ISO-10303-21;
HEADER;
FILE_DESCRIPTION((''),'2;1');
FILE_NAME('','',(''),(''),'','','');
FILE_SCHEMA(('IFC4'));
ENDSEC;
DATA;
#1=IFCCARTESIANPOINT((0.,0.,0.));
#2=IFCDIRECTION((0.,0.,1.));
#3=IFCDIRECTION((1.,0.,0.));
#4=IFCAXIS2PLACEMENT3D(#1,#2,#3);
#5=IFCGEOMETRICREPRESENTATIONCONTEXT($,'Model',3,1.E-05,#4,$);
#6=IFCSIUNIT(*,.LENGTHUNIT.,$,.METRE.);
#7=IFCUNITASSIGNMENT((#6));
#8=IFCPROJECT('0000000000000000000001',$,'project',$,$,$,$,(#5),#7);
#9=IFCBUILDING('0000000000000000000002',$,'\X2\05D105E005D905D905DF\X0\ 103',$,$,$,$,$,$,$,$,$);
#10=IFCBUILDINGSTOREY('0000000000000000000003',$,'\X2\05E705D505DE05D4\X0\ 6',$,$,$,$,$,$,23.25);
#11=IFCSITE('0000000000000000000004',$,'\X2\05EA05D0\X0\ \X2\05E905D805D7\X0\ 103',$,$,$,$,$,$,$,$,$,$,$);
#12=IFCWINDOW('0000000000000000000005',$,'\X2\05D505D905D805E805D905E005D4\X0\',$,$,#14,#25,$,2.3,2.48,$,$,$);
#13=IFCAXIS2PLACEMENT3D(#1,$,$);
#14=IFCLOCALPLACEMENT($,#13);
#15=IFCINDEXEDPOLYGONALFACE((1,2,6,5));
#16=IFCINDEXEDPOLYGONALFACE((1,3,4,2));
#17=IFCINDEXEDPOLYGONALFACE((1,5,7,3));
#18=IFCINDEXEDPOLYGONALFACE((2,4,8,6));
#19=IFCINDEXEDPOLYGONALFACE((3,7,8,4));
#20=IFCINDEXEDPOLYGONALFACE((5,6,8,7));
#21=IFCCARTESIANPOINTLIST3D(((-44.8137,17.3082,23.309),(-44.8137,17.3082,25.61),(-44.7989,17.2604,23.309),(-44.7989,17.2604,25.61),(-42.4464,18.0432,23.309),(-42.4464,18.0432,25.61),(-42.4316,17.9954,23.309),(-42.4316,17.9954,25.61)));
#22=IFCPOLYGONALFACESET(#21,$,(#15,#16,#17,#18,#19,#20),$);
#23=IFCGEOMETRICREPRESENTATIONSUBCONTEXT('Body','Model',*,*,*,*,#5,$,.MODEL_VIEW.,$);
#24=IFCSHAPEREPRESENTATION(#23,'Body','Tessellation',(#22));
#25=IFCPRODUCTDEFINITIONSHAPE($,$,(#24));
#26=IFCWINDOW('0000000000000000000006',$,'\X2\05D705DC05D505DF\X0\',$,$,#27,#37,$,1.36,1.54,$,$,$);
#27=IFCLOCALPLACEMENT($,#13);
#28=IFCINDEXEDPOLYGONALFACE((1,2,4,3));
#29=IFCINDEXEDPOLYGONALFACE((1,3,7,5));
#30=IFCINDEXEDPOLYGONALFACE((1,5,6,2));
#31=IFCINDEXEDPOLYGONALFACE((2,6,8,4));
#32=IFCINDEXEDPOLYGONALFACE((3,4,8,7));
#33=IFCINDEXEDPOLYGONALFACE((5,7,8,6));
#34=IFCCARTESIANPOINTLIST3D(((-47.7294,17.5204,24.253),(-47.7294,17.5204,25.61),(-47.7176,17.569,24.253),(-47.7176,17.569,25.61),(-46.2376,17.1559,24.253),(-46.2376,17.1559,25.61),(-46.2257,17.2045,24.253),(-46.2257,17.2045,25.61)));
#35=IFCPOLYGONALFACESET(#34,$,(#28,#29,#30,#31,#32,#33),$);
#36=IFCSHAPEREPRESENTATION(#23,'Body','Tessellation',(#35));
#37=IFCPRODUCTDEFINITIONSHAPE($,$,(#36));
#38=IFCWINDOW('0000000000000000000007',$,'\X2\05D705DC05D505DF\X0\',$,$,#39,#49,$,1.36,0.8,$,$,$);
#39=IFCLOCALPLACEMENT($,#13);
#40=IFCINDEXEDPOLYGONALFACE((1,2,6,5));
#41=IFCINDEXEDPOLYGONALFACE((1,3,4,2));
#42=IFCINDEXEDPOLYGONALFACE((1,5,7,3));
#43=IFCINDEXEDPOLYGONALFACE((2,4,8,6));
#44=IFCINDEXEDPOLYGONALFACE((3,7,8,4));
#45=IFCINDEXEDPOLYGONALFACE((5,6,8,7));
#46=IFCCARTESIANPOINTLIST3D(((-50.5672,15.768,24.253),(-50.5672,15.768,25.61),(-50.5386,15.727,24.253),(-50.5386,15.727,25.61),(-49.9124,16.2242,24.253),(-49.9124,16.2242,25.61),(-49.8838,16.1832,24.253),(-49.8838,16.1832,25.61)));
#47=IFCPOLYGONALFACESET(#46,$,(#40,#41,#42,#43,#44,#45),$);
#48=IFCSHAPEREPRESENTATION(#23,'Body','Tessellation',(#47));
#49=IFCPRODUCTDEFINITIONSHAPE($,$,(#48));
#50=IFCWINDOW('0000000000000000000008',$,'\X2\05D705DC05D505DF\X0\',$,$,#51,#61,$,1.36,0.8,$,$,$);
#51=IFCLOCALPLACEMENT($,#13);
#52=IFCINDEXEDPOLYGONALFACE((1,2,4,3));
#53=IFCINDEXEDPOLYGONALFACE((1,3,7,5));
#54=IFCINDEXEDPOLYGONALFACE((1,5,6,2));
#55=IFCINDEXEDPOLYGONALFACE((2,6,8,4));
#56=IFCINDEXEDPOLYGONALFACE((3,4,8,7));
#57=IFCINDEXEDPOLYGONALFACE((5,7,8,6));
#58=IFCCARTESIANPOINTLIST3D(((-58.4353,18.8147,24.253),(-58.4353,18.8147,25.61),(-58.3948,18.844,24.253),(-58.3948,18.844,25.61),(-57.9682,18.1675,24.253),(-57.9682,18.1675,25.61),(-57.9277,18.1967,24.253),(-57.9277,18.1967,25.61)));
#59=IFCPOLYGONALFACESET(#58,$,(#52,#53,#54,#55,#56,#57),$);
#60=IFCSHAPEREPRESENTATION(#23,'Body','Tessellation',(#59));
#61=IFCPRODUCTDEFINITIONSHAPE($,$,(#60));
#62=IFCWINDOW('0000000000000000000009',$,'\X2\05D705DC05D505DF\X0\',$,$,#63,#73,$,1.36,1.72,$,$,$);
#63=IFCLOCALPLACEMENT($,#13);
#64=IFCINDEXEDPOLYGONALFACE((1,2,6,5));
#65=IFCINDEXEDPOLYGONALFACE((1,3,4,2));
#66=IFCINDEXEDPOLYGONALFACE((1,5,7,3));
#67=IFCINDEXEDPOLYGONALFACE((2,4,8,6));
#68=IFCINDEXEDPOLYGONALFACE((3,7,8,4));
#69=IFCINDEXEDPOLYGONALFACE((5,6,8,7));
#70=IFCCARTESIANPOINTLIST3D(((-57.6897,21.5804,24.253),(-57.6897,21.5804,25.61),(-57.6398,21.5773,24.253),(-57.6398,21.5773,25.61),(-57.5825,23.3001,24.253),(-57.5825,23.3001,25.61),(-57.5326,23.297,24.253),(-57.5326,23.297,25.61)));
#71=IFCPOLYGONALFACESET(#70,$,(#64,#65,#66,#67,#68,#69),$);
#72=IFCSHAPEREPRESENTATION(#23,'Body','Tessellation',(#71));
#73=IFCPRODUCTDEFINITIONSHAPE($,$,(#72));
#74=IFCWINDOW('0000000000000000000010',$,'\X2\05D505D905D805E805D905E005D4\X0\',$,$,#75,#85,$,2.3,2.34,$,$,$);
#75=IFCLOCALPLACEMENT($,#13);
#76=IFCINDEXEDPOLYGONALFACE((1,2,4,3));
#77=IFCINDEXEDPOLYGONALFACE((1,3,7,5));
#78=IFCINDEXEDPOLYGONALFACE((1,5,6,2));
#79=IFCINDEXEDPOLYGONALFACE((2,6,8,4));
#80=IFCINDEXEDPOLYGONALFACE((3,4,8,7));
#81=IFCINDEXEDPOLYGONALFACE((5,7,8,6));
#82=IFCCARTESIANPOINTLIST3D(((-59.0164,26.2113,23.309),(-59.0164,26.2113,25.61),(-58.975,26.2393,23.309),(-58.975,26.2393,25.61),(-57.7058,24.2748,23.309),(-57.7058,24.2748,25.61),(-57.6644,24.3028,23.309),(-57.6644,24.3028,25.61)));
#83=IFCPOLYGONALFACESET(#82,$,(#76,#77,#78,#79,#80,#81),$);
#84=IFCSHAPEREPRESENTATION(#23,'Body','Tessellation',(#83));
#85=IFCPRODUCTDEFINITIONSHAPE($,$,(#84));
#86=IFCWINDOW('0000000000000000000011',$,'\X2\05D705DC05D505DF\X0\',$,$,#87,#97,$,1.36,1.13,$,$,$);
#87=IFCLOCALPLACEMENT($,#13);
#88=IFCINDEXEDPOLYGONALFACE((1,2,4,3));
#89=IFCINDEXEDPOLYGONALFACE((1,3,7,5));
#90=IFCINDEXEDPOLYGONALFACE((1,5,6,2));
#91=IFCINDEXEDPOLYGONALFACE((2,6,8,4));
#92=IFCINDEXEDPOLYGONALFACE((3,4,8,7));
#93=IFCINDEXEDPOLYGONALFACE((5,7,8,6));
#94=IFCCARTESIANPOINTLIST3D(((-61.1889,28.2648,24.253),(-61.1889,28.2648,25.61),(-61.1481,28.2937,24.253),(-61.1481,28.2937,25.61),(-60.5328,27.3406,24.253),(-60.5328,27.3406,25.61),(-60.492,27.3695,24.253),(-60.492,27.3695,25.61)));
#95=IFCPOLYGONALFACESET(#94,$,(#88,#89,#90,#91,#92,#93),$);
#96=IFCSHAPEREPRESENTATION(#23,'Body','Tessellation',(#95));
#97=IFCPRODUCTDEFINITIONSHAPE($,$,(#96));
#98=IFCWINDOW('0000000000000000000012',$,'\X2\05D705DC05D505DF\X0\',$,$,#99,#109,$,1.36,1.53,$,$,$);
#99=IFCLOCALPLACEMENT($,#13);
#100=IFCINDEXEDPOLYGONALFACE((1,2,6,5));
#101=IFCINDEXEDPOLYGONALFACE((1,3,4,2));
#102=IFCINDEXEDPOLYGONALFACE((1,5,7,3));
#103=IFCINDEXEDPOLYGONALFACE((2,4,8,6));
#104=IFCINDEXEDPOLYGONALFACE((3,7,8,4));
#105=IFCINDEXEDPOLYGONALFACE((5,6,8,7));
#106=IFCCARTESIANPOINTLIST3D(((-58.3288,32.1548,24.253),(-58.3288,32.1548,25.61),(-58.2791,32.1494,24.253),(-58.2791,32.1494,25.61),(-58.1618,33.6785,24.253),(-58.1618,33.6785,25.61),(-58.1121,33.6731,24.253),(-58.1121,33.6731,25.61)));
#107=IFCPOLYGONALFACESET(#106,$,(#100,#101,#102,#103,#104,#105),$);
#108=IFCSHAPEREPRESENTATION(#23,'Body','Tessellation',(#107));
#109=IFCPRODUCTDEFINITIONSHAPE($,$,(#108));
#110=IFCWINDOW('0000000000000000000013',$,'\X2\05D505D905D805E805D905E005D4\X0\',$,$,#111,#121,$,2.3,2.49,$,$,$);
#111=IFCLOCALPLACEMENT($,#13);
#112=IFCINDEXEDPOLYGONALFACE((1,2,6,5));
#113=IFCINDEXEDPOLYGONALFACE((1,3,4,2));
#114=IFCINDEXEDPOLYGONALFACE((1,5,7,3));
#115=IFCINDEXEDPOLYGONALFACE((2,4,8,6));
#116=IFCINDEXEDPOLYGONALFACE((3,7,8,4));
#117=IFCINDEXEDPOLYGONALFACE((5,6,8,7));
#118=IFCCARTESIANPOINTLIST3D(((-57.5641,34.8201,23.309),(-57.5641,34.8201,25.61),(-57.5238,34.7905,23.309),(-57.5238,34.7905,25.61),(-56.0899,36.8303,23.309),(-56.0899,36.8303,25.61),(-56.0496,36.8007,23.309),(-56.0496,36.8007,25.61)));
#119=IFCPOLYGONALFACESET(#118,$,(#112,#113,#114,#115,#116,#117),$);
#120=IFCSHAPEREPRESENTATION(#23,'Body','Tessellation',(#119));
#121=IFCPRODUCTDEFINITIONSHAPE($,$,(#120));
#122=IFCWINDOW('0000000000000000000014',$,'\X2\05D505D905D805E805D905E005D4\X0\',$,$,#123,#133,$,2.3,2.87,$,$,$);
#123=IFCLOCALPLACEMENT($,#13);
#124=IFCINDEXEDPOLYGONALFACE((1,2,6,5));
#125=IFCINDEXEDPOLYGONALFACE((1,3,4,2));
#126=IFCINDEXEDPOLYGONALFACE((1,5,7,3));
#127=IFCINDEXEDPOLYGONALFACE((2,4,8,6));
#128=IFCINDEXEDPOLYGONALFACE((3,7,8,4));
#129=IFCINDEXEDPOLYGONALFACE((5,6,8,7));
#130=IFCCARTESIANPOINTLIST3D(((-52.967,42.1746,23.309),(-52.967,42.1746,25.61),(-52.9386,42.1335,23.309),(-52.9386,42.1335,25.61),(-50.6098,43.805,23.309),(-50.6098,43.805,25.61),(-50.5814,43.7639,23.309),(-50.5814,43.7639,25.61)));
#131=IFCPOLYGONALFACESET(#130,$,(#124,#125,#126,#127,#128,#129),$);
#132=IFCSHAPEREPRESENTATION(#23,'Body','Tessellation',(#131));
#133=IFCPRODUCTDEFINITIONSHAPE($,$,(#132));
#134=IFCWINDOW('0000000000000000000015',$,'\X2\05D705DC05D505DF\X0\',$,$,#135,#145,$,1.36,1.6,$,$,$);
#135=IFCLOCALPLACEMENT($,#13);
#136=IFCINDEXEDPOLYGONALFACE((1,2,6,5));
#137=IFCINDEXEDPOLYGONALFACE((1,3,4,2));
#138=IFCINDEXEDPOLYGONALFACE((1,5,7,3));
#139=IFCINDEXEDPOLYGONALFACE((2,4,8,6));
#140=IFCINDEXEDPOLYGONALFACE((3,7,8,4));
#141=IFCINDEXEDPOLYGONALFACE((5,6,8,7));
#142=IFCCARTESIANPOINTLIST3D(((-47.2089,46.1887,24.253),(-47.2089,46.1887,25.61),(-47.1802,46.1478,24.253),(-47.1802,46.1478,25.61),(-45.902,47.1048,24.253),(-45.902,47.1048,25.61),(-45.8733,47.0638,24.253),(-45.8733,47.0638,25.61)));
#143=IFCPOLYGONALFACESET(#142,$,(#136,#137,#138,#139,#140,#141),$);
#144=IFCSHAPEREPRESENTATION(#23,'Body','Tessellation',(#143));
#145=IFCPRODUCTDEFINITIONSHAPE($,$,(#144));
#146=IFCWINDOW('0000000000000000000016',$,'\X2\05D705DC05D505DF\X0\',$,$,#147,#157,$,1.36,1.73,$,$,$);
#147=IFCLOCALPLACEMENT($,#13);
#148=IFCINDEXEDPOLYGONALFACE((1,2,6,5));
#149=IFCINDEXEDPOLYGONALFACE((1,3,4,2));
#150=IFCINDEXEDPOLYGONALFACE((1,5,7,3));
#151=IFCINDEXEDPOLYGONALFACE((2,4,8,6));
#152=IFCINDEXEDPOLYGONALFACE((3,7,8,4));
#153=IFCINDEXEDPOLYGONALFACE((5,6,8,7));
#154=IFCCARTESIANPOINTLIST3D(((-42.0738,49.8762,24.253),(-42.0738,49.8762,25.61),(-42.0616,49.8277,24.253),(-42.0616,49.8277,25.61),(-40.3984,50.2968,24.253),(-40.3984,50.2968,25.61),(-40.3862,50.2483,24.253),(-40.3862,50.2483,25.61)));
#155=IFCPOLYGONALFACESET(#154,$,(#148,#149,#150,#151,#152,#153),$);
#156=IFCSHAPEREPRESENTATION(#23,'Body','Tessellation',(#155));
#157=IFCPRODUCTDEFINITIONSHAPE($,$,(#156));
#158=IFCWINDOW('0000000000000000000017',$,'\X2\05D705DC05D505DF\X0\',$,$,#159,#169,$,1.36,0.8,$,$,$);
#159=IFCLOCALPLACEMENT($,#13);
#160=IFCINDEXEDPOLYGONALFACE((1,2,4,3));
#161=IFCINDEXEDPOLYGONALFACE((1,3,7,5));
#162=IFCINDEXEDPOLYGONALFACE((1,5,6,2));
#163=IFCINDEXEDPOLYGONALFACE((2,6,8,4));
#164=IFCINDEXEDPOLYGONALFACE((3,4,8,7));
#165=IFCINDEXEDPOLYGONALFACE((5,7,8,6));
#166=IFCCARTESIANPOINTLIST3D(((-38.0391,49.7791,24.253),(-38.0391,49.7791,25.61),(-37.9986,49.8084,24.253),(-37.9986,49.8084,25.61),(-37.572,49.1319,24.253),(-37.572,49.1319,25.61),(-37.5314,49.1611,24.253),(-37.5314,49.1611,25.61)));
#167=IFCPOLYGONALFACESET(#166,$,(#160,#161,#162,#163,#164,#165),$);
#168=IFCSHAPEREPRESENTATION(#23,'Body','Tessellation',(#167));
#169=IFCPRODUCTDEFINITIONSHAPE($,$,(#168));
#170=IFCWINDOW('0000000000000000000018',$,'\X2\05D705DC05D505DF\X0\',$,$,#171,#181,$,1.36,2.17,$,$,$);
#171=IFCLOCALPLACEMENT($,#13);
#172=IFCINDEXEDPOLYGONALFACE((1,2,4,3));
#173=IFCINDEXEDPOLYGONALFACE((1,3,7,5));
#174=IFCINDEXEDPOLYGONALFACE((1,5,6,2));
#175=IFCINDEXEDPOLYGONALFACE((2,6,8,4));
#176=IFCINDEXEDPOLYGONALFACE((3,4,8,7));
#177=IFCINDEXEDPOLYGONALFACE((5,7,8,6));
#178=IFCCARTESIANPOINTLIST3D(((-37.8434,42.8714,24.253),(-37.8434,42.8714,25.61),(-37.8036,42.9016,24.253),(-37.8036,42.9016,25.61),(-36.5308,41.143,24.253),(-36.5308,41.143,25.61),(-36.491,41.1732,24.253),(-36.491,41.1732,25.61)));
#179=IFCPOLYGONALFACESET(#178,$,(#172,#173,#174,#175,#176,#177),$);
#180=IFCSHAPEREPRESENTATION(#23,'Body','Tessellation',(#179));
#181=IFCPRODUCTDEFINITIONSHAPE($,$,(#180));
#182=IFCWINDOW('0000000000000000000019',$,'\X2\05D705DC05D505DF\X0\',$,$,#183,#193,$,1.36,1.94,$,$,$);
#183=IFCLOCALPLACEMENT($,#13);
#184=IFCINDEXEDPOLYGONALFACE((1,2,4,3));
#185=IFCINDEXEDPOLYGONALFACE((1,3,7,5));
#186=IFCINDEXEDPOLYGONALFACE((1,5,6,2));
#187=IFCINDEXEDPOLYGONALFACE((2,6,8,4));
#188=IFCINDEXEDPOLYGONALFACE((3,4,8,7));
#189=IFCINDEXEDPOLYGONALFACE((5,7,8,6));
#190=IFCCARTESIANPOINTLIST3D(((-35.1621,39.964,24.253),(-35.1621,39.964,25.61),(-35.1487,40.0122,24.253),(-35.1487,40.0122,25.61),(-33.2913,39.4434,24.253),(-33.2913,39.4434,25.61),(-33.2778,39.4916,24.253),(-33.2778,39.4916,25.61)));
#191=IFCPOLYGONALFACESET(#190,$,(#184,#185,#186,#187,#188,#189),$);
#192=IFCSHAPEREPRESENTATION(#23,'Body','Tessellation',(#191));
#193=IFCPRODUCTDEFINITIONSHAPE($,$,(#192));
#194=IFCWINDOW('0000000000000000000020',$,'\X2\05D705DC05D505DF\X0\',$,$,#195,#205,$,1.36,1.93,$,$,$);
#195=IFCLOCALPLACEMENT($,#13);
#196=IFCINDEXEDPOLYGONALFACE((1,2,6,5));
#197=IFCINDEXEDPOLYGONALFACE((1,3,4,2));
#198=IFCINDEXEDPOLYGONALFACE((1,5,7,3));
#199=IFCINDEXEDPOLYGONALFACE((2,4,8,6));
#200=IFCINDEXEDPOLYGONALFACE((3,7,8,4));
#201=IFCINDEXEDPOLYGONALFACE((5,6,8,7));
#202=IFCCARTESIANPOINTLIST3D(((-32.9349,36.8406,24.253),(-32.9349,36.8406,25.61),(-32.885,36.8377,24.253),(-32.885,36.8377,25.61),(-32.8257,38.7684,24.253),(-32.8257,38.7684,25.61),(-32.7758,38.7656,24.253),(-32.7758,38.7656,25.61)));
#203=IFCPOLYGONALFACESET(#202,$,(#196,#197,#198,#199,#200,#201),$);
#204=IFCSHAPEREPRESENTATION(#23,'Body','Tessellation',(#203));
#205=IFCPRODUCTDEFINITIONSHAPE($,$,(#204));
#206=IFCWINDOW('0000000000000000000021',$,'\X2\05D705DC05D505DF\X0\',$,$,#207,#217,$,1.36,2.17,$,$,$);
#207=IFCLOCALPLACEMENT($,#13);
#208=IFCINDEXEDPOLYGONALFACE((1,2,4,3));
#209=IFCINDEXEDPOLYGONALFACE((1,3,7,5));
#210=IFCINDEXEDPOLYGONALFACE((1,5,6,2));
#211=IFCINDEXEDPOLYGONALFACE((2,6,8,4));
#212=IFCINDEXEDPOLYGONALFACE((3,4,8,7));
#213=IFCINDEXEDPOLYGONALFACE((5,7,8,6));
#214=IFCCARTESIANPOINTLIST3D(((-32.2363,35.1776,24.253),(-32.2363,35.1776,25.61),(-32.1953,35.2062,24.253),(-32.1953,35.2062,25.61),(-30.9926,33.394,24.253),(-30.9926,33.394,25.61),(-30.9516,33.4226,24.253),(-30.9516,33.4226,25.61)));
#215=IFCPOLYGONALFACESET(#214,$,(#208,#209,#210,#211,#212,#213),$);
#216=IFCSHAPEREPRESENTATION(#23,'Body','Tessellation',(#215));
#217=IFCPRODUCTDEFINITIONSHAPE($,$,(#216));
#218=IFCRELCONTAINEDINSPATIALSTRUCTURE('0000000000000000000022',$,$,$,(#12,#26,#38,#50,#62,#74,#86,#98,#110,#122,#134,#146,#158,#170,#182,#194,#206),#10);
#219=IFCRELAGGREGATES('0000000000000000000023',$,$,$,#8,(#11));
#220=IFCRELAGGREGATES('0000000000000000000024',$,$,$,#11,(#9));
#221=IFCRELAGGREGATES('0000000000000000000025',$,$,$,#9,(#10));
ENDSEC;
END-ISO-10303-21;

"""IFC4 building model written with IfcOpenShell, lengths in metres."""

from ifc_helpers import new_model, si_unit, frame, origin_with_axes, context, subcontext, project, spatial, polyline, outline, extrude, element, save


model = new_model("IFC4")

# Units and contexts
model_context = context("Model", 3, precision=1e-05, world=origin_with_axes())
body_context = subcontext(model_context, "Body", "Model", "MODEL_VIEW")
ifc_project = project(units=[si_unit("LENGTHUNIT", "METRE")], contexts=[model_context])

# Site, building, storey
site = spatial("IfcSite", under=ifc_project, Name="תא שטח 103")
building = spatial("IfcBuilding", under=site, Name="בניין 103")
storey = spatial("IfcBuildingStorey", under=building, Name="קומה 6", Elevation=23.25)

# Windows
element("IfcWindow", 1, inside=storey, Name="ויטרינה", OverallHeight=2.3, OverallWidth=2.48, context=body_context, shape_type="SweptSolid", body=[
    extrude(outline(polyline([(-42.4464, 18.0432), (-44.8137, 17.3082), (-44.7989, 17.2604), (-42.4316, 17.9954), (-42.4464, 18.0432)])), frame((0.0, 0.0, 23.309)), (0.0, 0.0, 1.0), 2.301),
])
element("IfcWindow", 2, inside=storey, Name="חלון", OverallHeight=1.36, OverallWidth=1.54, context=body_context, shape_type="SweptSolid", body=[
    extrude(outline(polyline([(-46.2257, 17.2045), (-47.7176, 17.569), (-47.7294, 17.5204), (-46.2376, 17.1559), (-46.2257, 17.2045)])), frame((0.0, 0.0, 24.253)), (0.0, 0.0, 1.0), 1.357),
])
element("IfcWindow", 3, inside=storey, Name="חלון", OverallHeight=1.36, OverallWidth=0.8, context=body_context, shape_type="SweptSolid", body=[
    extrude(outline(polyline([(-49.9124, 16.2242), (-50.5672, 15.768), (-50.5386, 15.727), (-49.8838, 16.1832), (-49.9124, 16.2242)])), frame((0.0, 0.0, 24.253)), (0.0, 0.0, 1.0), 1.357),
])
element("IfcWindow", 4, inside=storey, Name="חלון", OverallHeight=1.36, OverallWidth=0.8, context=body_context, shape_type="SweptSolid", body=[
    extrude(outline(polyline([(-57.9277, 18.1967), (-58.3948, 18.844), (-58.4353, 18.8147), (-57.9682, 18.1675), (-57.9277, 18.1967)])), frame((0.0, 0.0, 24.253)), (0.0, 0.0, 1.0), 1.357),
])
element("IfcWindow", 5, inside=storey, Name="חלון", OverallHeight=1.36, OverallWidth=1.72, context=body_context, shape_type="SweptSolid", body=[
    extrude(outline(polyline([(-57.6398, 21.5773), (-57.5326, 23.297), (-57.5825, 23.3001), (-57.6897, 21.5804), (-57.6398, 21.5773)])), frame((0.0, 0.0, 24.253)), (0.0, 0.0, 1.0), 1.357),
])
element("IfcWindow", 6, inside=storey, Name="ויטרינה", OverallHeight=2.3, OverallWidth=2.34, context=body_context, shape_type="SweptSolid", body=[
    extrude(outline(polyline([(-57.6644, 24.3028), (-58.975, 26.2393), (-59.0164, 26.2113), (-57.7058, 24.2748), (-57.6644, 24.3028)])), frame((0.0, 0.0, 23.309)), (0.0, 0.0, 1.0), 2.301),
])
element("IfcWindow", 7, inside=storey, Name="חלון", OverallHeight=1.36, OverallWidth=1.13, context=body_context, shape_type="SweptSolid", body=[
    extrude(outline(polyline([(-60.492, 27.3695), (-61.1481, 28.2937), (-61.1889, 28.2648), (-60.5328, 27.3406), (-60.492, 27.3695)])), frame((0.0, 0.0, 24.253)), (0.0, 0.0, 1.0), 1.357),
])
element("IfcWindow", 8, inside=storey, Name="חלון", OverallHeight=1.36, OverallWidth=1.53, context=body_context, shape_type="SweptSolid", body=[
    extrude(outline(polyline([(-58.2791, 32.1494), (-58.1121, 33.6731), (-58.1618, 33.6785), (-58.3288, 32.1548), (-58.2791, 32.1494)])), frame((0.0, 0.0, 24.253)), (0.0, 0.0, 1.0), 1.357),
])
element("IfcWindow", 9, inside=storey, Name="ויטרינה", OverallHeight=2.3, OverallWidth=2.49, context=body_context, shape_type="SweptSolid", body=[
    extrude(outline(polyline([(-57.5238, 34.7905), (-56.0496, 36.8007), (-56.0899, 36.8303), (-57.5641, 34.8201), (-57.5238, 34.7905)])), frame((0.0, 0.0, 23.309)), (0.0, 0.0, 1.0), 2.301),
])
element("IfcWindow", 10, inside=storey, Name="ויטרינה", OverallHeight=2.3, OverallWidth=2.87, context=body_context, shape_type="SweptSolid", body=[
    extrude(outline(polyline([(-52.9386, 42.1335), (-50.5814, 43.7639), (-50.6098, 43.805), (-52.967, 42.1746), (-52.9386, 42.1335)])), frame((0.0, 0.0, 23.309)), (0.0, 0.0, 1.0), 2.301),
])
element("IfcWindow", 11, inside=storey, Name="חלון", OverallHeight=1.36, OverallWidth=1.6, context=body_context, shape_type="SweptSolid", body=[
    extrude(outline(polyline([(-47.1802, 46.1478), (-45.8733, 47.0638), (-45.902, 47.1048), (-47.2089, 46.1887), (-47.1802, 46.1478)])), frame((0.0, 0.0, 24.253)), (0.0, 0.0, 1.0), 1.357),
])
element("IfcWindow", 12, inside=storey, Name="חלון", OverallHeight=1.36, OverallWidth=1.73, context=body_context, shape_type="SweptSolid", body=[
    extrude(outline(polyline([(-42.0616, 49.8277), (-40.3862, 50.2483), (-40.3984, 50.2968), (-42.0738, 49.8762), (-42.0616, 49.8277)])), frame((0.0, 0.0, 24.253)), (0.0, 0.0, 1.0), 1.357),
])
element("IfcWindow", 13, inside=storey, Name="חלון", OverallHeight=1.36, OverallWidth=0.8, context=body_context, shape_type="SweptSolid", body=[
    extrude(outline(polyline([(-38.0391, 49.7791), (-37.572, 49.1319), (-37.5314, 49.1611), (-37.9986, 49.8084), (-38.0391, 49.7791)])), frame((0.0, 0.0, 24.253)), (0.0, 0.0, 1.0), 1.357),
])
element("IfcWindow", 14, inside=storey, Name="חלון", OverallHeight=1.36, OverallWidth=2.17, context=body_context, shape_type="SweptSolid", body=[
    extrude(outline(polyline([(-37.8434, 42.8714), (-36.5308, 41.143), (-36.491, 41.1732), (-37.8036, 42.9016), (-37.8434, 42.8714)])), frame((0.0, 0.0, 24.253)), (0.0, 0.0, 1.0), 1.357),
])
element("IfcWindow", 15, inside=storey, Name="חלון", OverallHeight=1.36, OverallWidth=1.94, context=body_context, shape_type="SweptSolid", body=[
    extrude(outline(polyline([(-35.1621, 39.964), (-33.2913, 39.4434), (-33.2778, 39.4916), (-35.1487, 40.0122), (-35.1621, 39.964)])), frame((0.0, 0.0, 24.253)), (0.0, 0.0, 1.0), 1.357),
])
element("IfcWindow", 16, inside=storey, Name="חלון", OverallHeight=1.36, OverallWidth=1.93, context=body_context, shape_type="SweptSolid", body=[
    extrude(outline(polyline([(-32.8257, 38.7684), (-32.9349, 36.8406), (-32.885, 36.8377), (-32.7758, 38.7656), (-32.8257, 38.7684)])), frame((0.0, 0.0, 24.253)), (0.0, 0.0, 1.0), 1.357),
])
element("IfcWindow", 17, inside=storey, Name="חלון", OverallHeight=1.36, OverallWidth=2.17, context=body_context, shape_type="SweptSolid", body=[
    extrude(outline(polyline([(-32.2363, 35.1776), (-30.9926, 33.394), (-30.9516, 33.4226), (-32.1953, 35.2062), (-32.2363, 35.1776)])), frame((0.0, 0.0, 24.253)), (0.0, 0.0, 1.0), 1.357),
])

save(model, "model.ifc")
